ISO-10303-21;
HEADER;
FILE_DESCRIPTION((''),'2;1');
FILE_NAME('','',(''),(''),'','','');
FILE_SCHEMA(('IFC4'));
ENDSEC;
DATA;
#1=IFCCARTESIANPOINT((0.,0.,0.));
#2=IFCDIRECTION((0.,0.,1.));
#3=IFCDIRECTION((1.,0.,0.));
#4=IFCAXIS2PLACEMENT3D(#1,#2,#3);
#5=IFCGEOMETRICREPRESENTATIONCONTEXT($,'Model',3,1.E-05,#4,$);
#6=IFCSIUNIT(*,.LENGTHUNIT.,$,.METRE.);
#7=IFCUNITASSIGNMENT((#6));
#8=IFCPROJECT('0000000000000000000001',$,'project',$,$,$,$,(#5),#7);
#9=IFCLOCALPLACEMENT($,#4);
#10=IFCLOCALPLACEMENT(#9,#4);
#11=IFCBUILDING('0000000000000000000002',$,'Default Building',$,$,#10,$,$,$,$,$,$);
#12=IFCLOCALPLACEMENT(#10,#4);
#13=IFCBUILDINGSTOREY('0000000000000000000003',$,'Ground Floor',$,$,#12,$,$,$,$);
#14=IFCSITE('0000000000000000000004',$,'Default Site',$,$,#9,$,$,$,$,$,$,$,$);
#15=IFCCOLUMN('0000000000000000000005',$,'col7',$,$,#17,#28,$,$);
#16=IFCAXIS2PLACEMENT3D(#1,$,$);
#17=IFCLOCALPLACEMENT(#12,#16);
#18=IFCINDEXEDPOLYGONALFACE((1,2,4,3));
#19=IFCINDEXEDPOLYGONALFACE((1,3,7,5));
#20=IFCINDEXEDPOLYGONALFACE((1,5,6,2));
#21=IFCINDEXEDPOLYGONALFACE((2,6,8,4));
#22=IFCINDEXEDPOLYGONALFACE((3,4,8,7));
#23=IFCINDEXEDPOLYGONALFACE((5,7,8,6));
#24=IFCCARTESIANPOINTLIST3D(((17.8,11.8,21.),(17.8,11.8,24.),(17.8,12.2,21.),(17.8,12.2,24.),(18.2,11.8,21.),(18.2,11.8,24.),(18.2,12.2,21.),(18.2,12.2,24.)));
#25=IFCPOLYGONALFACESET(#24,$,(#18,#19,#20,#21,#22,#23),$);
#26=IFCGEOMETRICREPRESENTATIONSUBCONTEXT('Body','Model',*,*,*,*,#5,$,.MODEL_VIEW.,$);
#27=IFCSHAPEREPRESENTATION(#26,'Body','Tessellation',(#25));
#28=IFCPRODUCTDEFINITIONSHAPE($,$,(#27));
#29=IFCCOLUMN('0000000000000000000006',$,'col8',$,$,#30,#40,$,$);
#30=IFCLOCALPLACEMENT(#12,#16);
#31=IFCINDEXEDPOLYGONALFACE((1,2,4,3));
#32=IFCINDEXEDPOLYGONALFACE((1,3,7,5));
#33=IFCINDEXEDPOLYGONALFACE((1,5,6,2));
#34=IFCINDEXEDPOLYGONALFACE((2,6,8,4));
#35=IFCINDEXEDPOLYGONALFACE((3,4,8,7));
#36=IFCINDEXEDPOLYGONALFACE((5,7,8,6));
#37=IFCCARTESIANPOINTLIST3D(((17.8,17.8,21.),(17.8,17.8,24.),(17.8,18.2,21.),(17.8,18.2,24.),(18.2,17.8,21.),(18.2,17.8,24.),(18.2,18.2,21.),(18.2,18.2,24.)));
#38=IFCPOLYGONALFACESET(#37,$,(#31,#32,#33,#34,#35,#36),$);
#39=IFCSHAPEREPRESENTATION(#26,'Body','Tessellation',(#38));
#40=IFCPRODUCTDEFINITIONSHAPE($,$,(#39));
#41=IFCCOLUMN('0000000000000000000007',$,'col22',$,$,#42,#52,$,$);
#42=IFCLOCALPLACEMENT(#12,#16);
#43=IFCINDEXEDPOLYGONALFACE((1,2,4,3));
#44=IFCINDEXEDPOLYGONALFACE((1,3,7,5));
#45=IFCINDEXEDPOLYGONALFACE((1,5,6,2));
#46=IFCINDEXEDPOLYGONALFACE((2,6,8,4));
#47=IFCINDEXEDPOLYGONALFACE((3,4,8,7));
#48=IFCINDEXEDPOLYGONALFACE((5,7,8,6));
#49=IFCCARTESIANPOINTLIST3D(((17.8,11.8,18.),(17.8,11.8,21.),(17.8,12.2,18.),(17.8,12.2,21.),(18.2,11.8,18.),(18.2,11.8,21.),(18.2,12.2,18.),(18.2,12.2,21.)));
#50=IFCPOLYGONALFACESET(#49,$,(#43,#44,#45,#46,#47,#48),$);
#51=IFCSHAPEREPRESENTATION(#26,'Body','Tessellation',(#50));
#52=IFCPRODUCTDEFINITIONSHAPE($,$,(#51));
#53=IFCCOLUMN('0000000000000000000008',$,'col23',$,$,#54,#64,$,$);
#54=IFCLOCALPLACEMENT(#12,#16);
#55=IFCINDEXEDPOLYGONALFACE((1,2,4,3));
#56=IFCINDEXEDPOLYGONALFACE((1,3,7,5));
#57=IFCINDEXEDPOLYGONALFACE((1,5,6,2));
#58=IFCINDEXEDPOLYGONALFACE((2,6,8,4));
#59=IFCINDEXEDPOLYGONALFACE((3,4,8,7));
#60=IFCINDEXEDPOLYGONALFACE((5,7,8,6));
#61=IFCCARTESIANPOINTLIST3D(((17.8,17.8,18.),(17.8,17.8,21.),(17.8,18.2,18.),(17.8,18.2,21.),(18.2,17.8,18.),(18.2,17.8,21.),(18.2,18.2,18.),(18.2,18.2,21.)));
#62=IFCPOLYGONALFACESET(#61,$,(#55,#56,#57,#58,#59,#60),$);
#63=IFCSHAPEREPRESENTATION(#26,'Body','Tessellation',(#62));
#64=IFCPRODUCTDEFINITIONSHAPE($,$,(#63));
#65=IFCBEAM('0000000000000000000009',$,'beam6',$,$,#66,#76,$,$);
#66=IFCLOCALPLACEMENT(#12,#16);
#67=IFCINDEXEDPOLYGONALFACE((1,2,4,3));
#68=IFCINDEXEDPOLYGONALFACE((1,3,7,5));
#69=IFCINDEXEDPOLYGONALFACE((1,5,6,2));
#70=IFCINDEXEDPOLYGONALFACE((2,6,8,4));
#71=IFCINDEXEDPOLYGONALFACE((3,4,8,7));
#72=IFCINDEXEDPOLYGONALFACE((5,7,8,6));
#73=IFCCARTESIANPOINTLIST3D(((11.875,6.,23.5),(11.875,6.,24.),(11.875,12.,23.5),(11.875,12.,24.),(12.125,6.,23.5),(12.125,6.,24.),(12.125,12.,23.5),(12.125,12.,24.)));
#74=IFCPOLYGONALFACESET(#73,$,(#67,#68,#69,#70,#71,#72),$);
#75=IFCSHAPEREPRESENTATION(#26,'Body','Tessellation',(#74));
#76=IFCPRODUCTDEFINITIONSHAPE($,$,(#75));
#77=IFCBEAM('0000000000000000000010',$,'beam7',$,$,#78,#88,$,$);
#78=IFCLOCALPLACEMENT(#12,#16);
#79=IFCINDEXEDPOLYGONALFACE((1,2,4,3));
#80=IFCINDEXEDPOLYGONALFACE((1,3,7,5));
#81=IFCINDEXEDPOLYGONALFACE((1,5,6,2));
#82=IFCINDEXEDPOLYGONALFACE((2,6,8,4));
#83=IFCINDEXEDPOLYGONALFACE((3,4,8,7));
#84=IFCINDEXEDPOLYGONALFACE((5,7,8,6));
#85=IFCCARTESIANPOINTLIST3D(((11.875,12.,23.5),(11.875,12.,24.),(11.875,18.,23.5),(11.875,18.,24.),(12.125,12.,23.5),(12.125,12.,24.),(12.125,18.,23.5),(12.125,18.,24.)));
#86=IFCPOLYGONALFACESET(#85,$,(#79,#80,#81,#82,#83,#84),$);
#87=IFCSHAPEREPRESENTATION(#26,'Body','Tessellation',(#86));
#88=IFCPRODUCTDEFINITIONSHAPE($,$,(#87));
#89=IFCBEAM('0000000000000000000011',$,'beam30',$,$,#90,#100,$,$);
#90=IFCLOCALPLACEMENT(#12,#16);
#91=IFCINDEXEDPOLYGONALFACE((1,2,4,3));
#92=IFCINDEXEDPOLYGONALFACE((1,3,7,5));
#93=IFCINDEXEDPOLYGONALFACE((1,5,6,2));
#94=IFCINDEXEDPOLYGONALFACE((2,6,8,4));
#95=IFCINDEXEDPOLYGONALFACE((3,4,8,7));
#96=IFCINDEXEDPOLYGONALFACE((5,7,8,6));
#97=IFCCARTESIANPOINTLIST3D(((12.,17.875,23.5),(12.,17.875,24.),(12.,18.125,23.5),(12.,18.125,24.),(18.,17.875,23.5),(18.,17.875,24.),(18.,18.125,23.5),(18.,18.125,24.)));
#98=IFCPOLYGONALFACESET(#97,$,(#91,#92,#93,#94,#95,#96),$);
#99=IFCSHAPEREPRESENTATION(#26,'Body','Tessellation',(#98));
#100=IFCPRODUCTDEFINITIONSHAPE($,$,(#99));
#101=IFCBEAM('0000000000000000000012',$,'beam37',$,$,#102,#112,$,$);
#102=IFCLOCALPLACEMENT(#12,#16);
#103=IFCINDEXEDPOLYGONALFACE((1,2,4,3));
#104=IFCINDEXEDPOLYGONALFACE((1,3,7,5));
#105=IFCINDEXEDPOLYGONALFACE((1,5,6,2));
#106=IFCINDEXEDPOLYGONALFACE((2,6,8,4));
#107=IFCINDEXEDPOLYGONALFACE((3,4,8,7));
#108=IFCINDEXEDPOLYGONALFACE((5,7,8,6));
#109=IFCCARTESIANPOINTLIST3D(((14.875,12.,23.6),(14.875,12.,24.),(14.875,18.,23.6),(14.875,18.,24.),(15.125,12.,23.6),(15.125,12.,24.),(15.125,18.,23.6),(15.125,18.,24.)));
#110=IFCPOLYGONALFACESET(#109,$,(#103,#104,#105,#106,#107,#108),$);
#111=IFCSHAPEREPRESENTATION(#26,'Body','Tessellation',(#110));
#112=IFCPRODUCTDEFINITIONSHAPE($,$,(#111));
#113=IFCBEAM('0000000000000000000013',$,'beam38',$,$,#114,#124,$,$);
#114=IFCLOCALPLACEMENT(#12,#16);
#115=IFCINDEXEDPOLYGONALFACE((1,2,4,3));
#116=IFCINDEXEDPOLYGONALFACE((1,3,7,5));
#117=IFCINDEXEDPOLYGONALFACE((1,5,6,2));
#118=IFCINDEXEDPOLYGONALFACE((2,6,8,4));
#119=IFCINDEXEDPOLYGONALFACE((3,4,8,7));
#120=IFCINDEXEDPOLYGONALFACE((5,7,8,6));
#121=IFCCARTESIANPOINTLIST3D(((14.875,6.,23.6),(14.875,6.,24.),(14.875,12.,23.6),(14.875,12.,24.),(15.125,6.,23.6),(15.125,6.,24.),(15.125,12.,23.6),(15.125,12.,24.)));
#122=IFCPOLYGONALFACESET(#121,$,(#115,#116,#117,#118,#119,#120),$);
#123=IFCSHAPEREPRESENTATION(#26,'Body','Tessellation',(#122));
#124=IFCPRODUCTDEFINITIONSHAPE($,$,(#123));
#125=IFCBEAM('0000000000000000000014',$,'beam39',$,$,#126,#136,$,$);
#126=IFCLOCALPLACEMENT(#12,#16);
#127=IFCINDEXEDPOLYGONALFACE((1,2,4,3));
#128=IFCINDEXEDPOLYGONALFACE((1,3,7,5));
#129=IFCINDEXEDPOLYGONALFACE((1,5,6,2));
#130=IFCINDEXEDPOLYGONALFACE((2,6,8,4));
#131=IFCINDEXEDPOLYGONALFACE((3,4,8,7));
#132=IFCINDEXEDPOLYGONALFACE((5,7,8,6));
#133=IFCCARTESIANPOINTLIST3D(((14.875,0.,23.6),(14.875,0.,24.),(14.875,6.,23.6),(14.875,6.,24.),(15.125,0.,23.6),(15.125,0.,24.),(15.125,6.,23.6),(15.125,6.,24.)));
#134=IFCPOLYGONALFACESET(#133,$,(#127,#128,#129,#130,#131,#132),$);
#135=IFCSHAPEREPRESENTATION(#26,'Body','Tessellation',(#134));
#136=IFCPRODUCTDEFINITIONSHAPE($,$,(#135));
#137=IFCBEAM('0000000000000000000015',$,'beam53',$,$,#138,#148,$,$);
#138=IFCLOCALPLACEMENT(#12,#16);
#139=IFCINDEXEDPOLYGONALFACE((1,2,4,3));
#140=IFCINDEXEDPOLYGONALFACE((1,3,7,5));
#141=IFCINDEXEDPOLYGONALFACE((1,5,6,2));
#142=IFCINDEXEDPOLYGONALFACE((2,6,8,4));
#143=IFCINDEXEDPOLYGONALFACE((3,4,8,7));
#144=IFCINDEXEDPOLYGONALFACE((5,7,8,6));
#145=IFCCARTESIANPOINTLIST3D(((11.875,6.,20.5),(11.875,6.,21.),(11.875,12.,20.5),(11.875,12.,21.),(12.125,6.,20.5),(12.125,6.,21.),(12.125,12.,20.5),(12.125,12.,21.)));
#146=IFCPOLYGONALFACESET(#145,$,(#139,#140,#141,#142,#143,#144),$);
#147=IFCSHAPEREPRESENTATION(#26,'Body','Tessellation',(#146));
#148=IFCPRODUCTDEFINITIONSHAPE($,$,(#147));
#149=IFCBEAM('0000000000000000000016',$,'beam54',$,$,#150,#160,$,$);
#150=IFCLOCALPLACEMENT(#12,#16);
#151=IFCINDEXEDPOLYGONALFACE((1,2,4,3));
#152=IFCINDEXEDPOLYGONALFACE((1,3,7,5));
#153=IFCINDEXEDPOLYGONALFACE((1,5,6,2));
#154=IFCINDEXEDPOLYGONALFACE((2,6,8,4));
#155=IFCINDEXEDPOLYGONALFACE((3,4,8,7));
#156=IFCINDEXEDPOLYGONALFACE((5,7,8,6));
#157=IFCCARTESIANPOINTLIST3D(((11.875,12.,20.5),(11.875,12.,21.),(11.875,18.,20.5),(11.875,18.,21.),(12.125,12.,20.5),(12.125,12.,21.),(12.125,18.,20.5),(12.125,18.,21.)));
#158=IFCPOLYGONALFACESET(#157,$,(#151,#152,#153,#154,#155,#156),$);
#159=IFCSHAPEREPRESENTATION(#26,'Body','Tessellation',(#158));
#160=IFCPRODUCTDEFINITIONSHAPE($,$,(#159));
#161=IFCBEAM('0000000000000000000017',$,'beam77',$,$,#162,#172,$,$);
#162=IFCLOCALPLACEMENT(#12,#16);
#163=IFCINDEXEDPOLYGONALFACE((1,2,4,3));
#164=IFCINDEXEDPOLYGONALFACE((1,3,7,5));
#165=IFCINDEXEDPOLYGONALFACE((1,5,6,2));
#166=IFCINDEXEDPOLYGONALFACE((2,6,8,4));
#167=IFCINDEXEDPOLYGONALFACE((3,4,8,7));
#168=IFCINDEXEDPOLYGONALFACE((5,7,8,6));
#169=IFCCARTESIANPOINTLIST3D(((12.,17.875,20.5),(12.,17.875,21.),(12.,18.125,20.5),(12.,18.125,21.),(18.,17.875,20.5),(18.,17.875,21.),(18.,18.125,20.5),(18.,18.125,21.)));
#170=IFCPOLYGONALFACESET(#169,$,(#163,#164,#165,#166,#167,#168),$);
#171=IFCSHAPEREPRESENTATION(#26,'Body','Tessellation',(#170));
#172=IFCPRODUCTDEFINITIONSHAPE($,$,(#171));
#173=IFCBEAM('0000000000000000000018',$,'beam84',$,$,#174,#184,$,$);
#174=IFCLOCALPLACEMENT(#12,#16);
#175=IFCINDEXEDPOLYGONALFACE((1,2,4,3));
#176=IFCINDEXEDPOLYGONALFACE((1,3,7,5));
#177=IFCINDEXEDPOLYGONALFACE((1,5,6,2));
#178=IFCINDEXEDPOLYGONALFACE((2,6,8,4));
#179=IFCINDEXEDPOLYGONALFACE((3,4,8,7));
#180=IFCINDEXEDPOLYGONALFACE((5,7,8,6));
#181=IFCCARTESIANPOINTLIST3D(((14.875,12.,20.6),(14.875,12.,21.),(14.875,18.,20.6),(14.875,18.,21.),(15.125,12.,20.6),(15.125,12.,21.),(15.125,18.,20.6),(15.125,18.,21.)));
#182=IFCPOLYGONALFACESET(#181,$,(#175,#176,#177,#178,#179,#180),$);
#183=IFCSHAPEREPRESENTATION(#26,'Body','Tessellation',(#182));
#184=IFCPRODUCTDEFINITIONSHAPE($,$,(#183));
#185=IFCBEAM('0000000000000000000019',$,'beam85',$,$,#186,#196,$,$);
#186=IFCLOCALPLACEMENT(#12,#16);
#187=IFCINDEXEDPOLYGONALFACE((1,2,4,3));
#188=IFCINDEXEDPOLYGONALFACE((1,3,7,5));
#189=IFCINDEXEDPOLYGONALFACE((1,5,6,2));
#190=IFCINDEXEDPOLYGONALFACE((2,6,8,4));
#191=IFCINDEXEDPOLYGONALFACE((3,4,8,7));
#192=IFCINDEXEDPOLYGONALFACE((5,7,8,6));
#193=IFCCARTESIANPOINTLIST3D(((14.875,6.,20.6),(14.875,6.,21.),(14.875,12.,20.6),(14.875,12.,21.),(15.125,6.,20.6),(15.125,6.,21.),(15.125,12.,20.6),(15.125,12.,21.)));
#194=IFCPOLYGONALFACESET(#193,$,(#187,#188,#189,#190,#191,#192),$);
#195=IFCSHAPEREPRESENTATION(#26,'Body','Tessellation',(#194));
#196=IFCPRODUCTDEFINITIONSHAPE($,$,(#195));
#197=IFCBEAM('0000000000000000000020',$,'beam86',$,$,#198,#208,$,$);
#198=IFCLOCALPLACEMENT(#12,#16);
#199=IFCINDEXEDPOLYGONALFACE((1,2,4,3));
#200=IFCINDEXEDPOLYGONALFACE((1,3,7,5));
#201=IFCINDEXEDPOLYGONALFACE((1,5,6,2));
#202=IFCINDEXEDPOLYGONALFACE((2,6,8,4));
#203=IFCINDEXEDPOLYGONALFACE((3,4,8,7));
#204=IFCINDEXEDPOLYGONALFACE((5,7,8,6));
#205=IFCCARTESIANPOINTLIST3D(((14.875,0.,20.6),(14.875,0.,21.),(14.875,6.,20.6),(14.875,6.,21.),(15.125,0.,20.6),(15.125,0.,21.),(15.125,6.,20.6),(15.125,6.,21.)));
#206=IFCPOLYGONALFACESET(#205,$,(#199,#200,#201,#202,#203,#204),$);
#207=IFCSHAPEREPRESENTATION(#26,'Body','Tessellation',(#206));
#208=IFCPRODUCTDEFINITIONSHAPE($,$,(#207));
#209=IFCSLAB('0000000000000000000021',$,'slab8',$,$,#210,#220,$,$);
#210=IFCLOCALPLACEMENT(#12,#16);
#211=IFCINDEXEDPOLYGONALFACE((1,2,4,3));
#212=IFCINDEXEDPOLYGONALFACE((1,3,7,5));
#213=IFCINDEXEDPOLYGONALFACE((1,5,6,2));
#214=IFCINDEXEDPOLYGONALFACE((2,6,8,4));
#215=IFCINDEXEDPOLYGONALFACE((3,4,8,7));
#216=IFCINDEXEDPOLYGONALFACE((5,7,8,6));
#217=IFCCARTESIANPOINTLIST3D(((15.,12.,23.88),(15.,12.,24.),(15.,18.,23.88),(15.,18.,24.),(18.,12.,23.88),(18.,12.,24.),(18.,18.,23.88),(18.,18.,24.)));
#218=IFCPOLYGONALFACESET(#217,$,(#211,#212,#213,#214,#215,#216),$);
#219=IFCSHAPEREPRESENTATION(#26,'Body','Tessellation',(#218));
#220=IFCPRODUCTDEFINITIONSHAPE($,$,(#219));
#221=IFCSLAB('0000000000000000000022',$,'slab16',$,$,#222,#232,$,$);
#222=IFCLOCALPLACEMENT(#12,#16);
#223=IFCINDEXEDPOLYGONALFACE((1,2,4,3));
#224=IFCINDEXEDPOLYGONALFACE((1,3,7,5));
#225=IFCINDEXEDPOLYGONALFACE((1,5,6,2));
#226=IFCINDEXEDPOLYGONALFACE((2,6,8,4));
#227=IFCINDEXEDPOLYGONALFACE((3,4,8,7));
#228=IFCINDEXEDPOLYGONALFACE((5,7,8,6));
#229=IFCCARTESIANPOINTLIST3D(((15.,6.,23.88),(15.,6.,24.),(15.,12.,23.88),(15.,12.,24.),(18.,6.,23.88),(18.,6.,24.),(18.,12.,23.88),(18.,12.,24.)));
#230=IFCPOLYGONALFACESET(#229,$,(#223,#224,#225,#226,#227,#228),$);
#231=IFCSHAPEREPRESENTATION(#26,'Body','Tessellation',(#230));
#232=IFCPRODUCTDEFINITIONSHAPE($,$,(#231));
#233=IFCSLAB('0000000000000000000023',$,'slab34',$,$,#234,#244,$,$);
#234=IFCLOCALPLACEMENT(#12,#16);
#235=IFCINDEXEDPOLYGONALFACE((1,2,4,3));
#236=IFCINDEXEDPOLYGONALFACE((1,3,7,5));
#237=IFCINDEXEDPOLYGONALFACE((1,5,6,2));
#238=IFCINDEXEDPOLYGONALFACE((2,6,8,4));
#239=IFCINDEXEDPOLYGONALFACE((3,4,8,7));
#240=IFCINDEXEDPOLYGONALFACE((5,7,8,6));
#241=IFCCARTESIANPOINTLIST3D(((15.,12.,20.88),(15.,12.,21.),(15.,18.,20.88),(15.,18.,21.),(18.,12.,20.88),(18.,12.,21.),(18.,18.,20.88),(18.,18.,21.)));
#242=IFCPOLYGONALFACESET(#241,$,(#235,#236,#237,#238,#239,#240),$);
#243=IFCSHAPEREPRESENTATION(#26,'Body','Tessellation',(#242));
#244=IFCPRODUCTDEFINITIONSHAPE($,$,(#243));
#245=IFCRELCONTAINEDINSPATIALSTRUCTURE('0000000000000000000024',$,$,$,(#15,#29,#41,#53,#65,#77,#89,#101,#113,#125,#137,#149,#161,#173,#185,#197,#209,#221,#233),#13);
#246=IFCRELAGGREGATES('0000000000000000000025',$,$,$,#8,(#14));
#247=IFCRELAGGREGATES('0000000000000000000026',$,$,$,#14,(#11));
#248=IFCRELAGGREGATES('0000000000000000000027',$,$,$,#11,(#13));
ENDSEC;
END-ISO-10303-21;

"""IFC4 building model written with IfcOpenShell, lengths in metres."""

from ifc_helpers import new_model, si_unit, frame, origin_with_axes, place, context, subcontext, project, spatial, indexed_curve, outline, extrude, element, save


model = new_model("IFC4")

# Units and contexts
model_context = context("Model", 3, precision=1e-05, world=origin_with_axes())
body_context = subcontext(model_context, "Body", "Model", "MODEL_VIEW")
ifc_project = project(units=[si_unit("LENGTHUNIT", "METRE")], contexts=[model_context])

# Site, building, storey
site_placement = place(None, origin_with_axes())
site = spatial("IfcSite", under=ifc_project, at=site_placement, Name="Default Site")
building_placement = place(site_placement, origin_with_axes())
building = spatial("IfcBuilding", under=site, at=building_placement, Name="Default Building")
storey_placement = place(building_placement, origin_with_axes())
storey = spatial("IfcBuildingStorey", under=building, at=storey_placement, Name="Ground Floor")

# Columns
for number, where, z_axis, x_axis, name in (
    (1, (17.8, 11.8, 21.0), (0.0, 0.0, 1.0), (1.0, 0.0, 0.0), "col7"),
    (2, (17.8, 17.8, 21.0), (0.0, 0.0, 1.0), (1.0, 0.0, 0.0), "col8"),
    (3, (17.8, 11.8, 18.0), (0.0, 0.0, 1.0), (1.0, 0.0, 0.0), "col22"),
    (4, (17.8, 17.8, 18.0), (0.0, 0.0, 1.0), (1.0, 0.0, 0.0), "col23"),
):
    element("IfcColumn", number, at=place(storey_placement, frame(where, z_axis=z_axis, x_axis=x_axis)), inside=storey, Name=name, context=body_context, shape_type="SweptSolid", body=[
        extrude(outline(indexed_curve([(0.0, 0.0), (0.0, 0.4), (0.4, 0.4), (0.4, 0.0), (0.0, 0.0)], self_intersect=False)), origin_with_axes(), (0.0, 0.0, 1.0), 3.0),
    ])

# Beams
for number, where, z_axis, x_axis, name in (
    (5, (12.125, 6.0, 23.5), (0.0, 0.0, 1.0), (0.0, 1.0, 0.0), "beam6"),
    (6, (12.125, 12.0, 23.5), (0.0, 0.0, 1.0), (0.0, 1.0, 0.0), "beam7"),
    (7, (12.0, 17.875, 23.5), (0.0, 0.0, 1.0), (1.0, 0.0, 0.0), "beam30"),
):
    element("IfcBeam", number, at=place(storey_placement, frame(where, z_axis=z_axis, x_axis=x_axis)), inside=storey, Name=name, context=body_context, shape_type="SweptSolid", body=[
        extrude(outline(indexed_curve([(0.0, 0.0), (0.0, 0.25), (6.0, 0.25), (6.0, 0.0), (0.0, 0.0)], self_intersect=False)), origin_with_axes(), (0.0, 0.0, 1.0), 0.5),
    ])
for number, where, z_axis, x_axis, name in (
    (8, (14.875, 18.0, 23.6), (0.0, 0.0, 1.0), (0.0, -1.0, 0.0), "beam37"),
    (9, (14.875, 12.0, 23.6), (0.0, 0.0, 1.0), (0.0, -1.0, 0.0), "beam38"),
    (10, (14.875, 6.0, 23.6), (0.0, 0.0, 1.0), (0.0, -1.0, 0.0), "beam39"),
):
    element("IfcBeam", number, at=place(storey_placement, frame(where, z_axis=z_axis, x_axis=x_axis)), inside=storey, Name=name, context=body_context, shape_type="SweptSolid", body=[
        extrude(outline(indexed_curve([(0.0, 0.0), (0.0, 0.25), (6.0, 0.25), (6.0, 0.0), (0.0, 0.0)], self_intersect=False)), origin_with_axes(), (0.0, 0.0, 1.0), 0.4),
    ])
for number, where, z_axis, x_axis, name in (
    (11, (12.125, 6.0, 20.5), (0.0, 0.0, 1.0), (0.0, 1.0, 0.0), "beam53"),
    (12, (12.125, 12.0, 20.5), (0.0, 0.0, 1.0), (0.0, 1.0, 0.0), "beam54"),
    (13, (12.0, 17.875, 20.5), (0.0, 0.0, 1.0), (1.0, 0.0, 0.0), "beam77"),
):
    element("IfcBeam", number, at=place(storey_placement, frame(where, z_axis=z_axis, x_axis=x_axis)), inside=storey, Name=name, context=body_context, shape_type="SweptSolid", body=[
        extrude(outline(indexed_curve([(0.0, 0.0), (0.0, 0.25), (6.0, 0.25), (6.0, 0.0), (0.0, 0.0)], self_intersect=False)), origin_with_axes(), (0.0, 0.0, 1.0), 0.5),
    ])
for number, where, z_axis, x_axis, name in (
    (14, (14.875, 18.0, 20.6), (0.0, 0.0, 1.0), (0.0, -1.0, 0.0), "beam84"),
    (15, (14.875, 12.0, 20.6), (0.0, 0.0, 1.0), (0.0, -1.0, 0.0), "beam85"),
    (16, (14.875, 6.0, 20.6), (0.0, 0.0, 1.0), (0.0, -1.0, 0.0), "beam86"),
):
    element("IfcBeam", number, at=place(storey_placement, frame(where, z_axis=z_axis, x_axis=x_axis)), inside=storey, Name=name, context=body_context, shape_type="SweptSolid", body=[
        extrude(outline(indexed_curve([(0.0, 0.0), (0.0, 0.25), (6.0, 0.25), (6.0, 0.0), (0.0, 0.0)], self_intersect=False)), origin_with_axes(), (0.0, 0.0, 1.0), 0.4),
    ])

# Slabs
for number, where, z_axis, x_axis, name in (
    (17, (15.0, 12.0, 23.88), (0.0, 0.0, 1.0), (1.0, 0.0, 0.0), "slab8"),
    (18, (15.0, 6.0, 23.88), (0.0, 0.0, 1.0), (1.0, 0.0, 0.0), "slab16"),
    (19, (15.0, 12.0, 20.88), (0.0, 0.0, 1.0), (1.0, 0.0, 0.0), "slab34"),
):
    element("IfcSlab", number, at=place(storey_placement, frame(where, z_axis=z_axis, x_axis=x_axis)), inside=storey, Name=name, context=body_context, shape_type="SweptSolid", body=[
        extrude(outline(indexed_curve([(0.0, 0.0), (0.0, 6.0), (3.0, 6.0), (3.0, 0.0), (0.0, 0.0)], self_intersect=False)), origin_with_axes(), (0.0, 0.0, 1.0), 0.12),
    ])

save(model, "model.ifc")
